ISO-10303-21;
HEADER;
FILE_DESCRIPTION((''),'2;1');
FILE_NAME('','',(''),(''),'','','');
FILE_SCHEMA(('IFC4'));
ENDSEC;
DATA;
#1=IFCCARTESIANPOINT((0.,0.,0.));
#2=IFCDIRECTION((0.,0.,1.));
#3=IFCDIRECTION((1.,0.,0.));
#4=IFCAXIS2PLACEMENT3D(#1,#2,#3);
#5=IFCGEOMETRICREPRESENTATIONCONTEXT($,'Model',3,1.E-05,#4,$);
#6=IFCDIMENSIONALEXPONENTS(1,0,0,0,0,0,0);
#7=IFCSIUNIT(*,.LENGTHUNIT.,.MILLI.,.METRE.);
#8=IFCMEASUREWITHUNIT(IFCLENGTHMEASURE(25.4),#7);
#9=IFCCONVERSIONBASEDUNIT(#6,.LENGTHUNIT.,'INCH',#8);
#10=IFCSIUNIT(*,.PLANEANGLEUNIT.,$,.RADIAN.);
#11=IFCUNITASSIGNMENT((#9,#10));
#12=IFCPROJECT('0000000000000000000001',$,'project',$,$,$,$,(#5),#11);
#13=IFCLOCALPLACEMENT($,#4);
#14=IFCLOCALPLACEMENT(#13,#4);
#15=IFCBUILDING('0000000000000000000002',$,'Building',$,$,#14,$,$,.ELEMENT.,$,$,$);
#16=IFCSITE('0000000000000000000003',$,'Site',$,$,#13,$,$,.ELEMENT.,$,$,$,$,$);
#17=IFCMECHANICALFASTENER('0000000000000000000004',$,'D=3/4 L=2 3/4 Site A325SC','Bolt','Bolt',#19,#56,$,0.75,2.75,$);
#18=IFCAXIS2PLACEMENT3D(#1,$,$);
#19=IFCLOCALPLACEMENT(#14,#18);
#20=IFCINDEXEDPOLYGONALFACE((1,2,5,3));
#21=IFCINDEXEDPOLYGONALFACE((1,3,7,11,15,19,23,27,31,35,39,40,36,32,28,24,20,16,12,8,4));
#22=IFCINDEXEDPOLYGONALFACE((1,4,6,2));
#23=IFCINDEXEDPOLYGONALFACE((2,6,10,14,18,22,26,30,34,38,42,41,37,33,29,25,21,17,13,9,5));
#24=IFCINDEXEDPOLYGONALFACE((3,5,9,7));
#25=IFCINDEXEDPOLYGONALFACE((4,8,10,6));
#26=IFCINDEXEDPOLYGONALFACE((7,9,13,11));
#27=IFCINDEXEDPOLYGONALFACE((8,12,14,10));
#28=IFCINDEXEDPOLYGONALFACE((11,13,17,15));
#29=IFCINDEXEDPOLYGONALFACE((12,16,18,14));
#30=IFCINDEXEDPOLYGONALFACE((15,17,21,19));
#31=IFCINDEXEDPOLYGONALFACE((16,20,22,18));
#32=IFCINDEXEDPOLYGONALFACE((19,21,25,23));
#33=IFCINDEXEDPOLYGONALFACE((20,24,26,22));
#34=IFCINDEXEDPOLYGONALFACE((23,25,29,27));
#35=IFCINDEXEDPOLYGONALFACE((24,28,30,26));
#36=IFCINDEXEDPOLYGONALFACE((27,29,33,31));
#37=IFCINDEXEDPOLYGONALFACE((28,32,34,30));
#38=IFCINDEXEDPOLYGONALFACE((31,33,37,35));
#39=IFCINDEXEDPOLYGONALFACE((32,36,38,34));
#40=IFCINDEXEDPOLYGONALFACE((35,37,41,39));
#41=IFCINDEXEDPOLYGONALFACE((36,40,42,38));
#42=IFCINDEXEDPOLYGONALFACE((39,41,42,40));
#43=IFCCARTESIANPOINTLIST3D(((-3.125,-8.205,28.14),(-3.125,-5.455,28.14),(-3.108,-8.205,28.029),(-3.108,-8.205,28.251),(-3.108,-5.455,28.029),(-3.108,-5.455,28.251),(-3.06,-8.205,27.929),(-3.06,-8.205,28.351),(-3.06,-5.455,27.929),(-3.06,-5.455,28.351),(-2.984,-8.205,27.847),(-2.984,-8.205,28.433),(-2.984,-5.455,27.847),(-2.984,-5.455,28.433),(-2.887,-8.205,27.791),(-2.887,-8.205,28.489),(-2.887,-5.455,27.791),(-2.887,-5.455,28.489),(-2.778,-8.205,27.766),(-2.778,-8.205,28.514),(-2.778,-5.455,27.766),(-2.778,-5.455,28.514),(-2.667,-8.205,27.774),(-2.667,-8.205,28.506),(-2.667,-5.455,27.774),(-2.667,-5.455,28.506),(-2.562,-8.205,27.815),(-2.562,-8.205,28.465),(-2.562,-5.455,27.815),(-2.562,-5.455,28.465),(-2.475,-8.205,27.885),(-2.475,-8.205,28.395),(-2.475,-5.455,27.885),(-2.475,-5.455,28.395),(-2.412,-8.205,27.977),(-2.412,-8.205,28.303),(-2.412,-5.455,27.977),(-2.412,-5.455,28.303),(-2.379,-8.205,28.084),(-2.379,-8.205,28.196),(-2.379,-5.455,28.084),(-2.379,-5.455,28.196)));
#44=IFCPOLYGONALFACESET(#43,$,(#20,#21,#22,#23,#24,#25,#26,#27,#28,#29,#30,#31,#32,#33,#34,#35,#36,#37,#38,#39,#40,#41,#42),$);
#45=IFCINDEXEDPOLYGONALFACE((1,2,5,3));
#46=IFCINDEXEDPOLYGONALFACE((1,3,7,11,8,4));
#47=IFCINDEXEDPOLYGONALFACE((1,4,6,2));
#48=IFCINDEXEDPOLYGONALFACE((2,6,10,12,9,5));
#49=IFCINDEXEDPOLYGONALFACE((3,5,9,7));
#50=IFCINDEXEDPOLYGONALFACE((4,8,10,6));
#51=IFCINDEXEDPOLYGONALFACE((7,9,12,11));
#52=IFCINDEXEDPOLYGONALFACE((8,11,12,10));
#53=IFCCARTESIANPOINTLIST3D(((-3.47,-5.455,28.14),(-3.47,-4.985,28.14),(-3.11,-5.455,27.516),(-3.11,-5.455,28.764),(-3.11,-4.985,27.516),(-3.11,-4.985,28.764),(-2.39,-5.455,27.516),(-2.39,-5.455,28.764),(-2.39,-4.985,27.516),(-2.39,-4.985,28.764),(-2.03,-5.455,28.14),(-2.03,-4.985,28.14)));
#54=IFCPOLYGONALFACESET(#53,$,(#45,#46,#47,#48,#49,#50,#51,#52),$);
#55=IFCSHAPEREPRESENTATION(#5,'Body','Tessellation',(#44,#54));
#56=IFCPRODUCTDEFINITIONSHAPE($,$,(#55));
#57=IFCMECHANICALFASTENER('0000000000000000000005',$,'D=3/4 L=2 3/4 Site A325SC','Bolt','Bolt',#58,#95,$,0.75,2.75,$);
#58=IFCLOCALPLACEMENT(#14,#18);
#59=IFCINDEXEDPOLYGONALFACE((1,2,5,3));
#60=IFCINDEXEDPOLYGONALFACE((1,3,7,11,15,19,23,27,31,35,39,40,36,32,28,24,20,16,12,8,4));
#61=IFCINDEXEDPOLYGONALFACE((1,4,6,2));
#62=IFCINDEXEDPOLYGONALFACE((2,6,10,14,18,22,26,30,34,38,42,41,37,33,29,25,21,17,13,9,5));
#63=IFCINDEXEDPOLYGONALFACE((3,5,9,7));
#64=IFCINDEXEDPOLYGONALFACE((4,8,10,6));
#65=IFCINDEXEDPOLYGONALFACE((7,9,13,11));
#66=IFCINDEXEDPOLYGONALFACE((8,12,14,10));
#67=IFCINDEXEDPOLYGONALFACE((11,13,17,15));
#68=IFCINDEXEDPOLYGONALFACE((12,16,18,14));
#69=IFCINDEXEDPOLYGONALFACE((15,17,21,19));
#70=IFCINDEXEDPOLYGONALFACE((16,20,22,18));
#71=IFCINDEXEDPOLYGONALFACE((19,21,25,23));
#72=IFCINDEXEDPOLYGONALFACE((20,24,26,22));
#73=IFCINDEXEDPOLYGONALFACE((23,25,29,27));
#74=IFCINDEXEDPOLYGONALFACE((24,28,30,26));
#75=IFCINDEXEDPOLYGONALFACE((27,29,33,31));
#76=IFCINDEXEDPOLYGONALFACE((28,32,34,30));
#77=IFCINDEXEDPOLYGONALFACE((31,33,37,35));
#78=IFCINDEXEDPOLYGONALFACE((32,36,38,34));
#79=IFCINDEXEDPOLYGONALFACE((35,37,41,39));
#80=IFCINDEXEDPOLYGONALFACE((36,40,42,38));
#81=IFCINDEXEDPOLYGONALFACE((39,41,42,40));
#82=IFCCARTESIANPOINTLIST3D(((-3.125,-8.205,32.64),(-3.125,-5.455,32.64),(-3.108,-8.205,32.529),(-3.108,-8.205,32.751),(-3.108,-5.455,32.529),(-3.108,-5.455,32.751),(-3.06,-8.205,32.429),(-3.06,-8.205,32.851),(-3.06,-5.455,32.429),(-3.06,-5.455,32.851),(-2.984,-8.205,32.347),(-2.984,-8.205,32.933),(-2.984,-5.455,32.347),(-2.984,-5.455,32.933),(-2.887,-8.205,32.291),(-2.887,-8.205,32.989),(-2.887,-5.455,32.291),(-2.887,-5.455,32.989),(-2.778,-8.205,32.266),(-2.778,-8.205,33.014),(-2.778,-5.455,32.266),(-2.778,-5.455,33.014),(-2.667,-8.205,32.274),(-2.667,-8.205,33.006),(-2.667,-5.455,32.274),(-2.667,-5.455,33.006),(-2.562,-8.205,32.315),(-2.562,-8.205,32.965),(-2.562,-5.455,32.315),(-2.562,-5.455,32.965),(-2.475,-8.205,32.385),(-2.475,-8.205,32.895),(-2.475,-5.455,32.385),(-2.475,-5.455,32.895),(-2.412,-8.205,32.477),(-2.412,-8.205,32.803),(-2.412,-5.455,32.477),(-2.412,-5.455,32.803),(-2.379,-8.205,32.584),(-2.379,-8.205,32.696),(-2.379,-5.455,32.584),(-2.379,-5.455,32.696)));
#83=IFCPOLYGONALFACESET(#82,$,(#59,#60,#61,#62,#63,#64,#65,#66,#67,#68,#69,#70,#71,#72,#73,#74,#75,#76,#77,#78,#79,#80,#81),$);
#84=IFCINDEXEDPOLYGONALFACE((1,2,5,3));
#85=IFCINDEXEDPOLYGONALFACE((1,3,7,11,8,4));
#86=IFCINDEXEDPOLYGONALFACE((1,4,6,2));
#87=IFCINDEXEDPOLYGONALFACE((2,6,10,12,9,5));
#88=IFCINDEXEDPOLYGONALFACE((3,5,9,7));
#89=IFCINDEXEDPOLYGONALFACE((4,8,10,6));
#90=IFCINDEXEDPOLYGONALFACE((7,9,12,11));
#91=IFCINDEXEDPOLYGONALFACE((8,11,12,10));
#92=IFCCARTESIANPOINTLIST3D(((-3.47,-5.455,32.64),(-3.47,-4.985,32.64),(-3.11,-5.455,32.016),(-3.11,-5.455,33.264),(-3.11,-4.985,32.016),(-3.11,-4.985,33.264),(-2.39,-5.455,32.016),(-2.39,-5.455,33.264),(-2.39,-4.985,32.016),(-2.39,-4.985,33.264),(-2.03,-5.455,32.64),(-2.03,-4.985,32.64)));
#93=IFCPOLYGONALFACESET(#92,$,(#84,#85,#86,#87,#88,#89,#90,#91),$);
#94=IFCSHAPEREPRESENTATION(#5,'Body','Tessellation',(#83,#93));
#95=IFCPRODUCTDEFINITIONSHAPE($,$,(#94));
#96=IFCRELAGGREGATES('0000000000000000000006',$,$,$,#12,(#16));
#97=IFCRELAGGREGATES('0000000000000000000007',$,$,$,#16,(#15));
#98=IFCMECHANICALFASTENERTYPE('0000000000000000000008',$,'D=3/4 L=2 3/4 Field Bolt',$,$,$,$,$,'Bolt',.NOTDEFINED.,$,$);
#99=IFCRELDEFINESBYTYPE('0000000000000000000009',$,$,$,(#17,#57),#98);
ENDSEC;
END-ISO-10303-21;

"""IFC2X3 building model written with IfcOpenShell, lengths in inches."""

from ifc_helpers import new_model, entity, si_unit, converted_unit, frame, origin_with_axes, origin_2d_with_axis, place, context, project, spatial, polyline, circle, outline, extrude, source, transform, mapped, type_object, type_shapes, element, save


model = new_model("IFC2X3")

# Units and contexts
model_context = context("Model", 3, precision=1e-05, world=origin_with_axes())
ifc_project = project(units=[converted_unit("LENGTHUNIT", "INCH", entity("IfcLengthMeasure", 25.4), si_unit("LENGTHUNIT", "METRE", prefix="MILLI"), dimensions=[1, 0, 0, 0, 0, 0, 0]), si_unit("PLANEANGLEUNIT", "RADIAN")], contexts=[model_context])

# Site, building
site_placement = place(None, origin_with_axes())
site = spatial("IfcSite", under=ifc_project, at=site_placement, Name="Site", CompositionType="ELEMENT")
building_placement = place(site_placement, origin_with_axes())
building = spatial("IfcBuilding", under=site, at=building_placement, Name="Building", CompositionType="ELEMENT")

# Mechanical fasteners
placement_1 = place(building_placement, frame((0.0, 0.0, 46.0), z_axis=(0.0, 0.0, 1.0), x_axis=(0.0, -1.0, 0.0)))
mechanical_fastener_type_1 = type_object("IfcMechanicalFastenerType", Name="D=3/4 L=2 3/4 Field Bolt", ElementType="Bolt")
shared_shape_1 = source(origin_with_axes(), model_context, "Body", "SweptSolid", [
    extrude(circle(Radius=0.375, at=origin_2d_with_axis()), frame((0.0, 0.0, 0.0), z_axis=(1.0, 0.0, 0.0), x_axis=(0.0, 1.0, 0.0)), (0.0, 0.0, 1.0), 2.75),
    extrude(outline(polyline([(-0.72, 0.0), (-0.36, 0.624), (0.36, 0.624), (0.72, 0.0), (0.36, -0.624), (-0.36, -0.624), (-0.72, 0.0)])), frame((0.0, 0.0, 0.0), z_axis=(1.0, 0.0, 0.0), x_axis=(0.0, 1.0, 0.0)), (0.0, 0.0, -1.0), 0.47),
])
type_shapes(mechanical_fastener_type_1, [shared_shape_1])
placement_2 = place(placement_1, frame((5.455, -2.75, 2.0), z_axis=(0.0, 0.0, -1.0), x_axis=(1.0, 0.0, 0.0)))
for number, where, z_axis, x_axis, name in (
    (1, (0.0, 0.0, 19.86), (0.0, 0.0, 1.0), (1.0, 0.0, 0.0), "D=3/4 L=2 3/4 Site A325SC"),
    (2, (0.0, 0.0, 15.36), (0.0, 0.0, 1.0), (1.0, 0.0, 0.0), "D=3/4 L=2 3/4 Site A325SC"),
):
    element("IfcMechanicalFastener", number, at=place(placement_2, frame(where, z_axis=z_axis, x_axis=x_axis)), type_object=mechanical_fastener_type_1, Name=name, Description="Bolt", ObjectType="Bolt", NominalDiameter=0.75, NominalLength=2.75, context=model_context, shape_type="MappedRepresentation", body=[
        mapped(shared_shape_1, transform((0.0, 0.0, 0.0), scale=1.0)),
    ])

save(model, "model.ifc")
